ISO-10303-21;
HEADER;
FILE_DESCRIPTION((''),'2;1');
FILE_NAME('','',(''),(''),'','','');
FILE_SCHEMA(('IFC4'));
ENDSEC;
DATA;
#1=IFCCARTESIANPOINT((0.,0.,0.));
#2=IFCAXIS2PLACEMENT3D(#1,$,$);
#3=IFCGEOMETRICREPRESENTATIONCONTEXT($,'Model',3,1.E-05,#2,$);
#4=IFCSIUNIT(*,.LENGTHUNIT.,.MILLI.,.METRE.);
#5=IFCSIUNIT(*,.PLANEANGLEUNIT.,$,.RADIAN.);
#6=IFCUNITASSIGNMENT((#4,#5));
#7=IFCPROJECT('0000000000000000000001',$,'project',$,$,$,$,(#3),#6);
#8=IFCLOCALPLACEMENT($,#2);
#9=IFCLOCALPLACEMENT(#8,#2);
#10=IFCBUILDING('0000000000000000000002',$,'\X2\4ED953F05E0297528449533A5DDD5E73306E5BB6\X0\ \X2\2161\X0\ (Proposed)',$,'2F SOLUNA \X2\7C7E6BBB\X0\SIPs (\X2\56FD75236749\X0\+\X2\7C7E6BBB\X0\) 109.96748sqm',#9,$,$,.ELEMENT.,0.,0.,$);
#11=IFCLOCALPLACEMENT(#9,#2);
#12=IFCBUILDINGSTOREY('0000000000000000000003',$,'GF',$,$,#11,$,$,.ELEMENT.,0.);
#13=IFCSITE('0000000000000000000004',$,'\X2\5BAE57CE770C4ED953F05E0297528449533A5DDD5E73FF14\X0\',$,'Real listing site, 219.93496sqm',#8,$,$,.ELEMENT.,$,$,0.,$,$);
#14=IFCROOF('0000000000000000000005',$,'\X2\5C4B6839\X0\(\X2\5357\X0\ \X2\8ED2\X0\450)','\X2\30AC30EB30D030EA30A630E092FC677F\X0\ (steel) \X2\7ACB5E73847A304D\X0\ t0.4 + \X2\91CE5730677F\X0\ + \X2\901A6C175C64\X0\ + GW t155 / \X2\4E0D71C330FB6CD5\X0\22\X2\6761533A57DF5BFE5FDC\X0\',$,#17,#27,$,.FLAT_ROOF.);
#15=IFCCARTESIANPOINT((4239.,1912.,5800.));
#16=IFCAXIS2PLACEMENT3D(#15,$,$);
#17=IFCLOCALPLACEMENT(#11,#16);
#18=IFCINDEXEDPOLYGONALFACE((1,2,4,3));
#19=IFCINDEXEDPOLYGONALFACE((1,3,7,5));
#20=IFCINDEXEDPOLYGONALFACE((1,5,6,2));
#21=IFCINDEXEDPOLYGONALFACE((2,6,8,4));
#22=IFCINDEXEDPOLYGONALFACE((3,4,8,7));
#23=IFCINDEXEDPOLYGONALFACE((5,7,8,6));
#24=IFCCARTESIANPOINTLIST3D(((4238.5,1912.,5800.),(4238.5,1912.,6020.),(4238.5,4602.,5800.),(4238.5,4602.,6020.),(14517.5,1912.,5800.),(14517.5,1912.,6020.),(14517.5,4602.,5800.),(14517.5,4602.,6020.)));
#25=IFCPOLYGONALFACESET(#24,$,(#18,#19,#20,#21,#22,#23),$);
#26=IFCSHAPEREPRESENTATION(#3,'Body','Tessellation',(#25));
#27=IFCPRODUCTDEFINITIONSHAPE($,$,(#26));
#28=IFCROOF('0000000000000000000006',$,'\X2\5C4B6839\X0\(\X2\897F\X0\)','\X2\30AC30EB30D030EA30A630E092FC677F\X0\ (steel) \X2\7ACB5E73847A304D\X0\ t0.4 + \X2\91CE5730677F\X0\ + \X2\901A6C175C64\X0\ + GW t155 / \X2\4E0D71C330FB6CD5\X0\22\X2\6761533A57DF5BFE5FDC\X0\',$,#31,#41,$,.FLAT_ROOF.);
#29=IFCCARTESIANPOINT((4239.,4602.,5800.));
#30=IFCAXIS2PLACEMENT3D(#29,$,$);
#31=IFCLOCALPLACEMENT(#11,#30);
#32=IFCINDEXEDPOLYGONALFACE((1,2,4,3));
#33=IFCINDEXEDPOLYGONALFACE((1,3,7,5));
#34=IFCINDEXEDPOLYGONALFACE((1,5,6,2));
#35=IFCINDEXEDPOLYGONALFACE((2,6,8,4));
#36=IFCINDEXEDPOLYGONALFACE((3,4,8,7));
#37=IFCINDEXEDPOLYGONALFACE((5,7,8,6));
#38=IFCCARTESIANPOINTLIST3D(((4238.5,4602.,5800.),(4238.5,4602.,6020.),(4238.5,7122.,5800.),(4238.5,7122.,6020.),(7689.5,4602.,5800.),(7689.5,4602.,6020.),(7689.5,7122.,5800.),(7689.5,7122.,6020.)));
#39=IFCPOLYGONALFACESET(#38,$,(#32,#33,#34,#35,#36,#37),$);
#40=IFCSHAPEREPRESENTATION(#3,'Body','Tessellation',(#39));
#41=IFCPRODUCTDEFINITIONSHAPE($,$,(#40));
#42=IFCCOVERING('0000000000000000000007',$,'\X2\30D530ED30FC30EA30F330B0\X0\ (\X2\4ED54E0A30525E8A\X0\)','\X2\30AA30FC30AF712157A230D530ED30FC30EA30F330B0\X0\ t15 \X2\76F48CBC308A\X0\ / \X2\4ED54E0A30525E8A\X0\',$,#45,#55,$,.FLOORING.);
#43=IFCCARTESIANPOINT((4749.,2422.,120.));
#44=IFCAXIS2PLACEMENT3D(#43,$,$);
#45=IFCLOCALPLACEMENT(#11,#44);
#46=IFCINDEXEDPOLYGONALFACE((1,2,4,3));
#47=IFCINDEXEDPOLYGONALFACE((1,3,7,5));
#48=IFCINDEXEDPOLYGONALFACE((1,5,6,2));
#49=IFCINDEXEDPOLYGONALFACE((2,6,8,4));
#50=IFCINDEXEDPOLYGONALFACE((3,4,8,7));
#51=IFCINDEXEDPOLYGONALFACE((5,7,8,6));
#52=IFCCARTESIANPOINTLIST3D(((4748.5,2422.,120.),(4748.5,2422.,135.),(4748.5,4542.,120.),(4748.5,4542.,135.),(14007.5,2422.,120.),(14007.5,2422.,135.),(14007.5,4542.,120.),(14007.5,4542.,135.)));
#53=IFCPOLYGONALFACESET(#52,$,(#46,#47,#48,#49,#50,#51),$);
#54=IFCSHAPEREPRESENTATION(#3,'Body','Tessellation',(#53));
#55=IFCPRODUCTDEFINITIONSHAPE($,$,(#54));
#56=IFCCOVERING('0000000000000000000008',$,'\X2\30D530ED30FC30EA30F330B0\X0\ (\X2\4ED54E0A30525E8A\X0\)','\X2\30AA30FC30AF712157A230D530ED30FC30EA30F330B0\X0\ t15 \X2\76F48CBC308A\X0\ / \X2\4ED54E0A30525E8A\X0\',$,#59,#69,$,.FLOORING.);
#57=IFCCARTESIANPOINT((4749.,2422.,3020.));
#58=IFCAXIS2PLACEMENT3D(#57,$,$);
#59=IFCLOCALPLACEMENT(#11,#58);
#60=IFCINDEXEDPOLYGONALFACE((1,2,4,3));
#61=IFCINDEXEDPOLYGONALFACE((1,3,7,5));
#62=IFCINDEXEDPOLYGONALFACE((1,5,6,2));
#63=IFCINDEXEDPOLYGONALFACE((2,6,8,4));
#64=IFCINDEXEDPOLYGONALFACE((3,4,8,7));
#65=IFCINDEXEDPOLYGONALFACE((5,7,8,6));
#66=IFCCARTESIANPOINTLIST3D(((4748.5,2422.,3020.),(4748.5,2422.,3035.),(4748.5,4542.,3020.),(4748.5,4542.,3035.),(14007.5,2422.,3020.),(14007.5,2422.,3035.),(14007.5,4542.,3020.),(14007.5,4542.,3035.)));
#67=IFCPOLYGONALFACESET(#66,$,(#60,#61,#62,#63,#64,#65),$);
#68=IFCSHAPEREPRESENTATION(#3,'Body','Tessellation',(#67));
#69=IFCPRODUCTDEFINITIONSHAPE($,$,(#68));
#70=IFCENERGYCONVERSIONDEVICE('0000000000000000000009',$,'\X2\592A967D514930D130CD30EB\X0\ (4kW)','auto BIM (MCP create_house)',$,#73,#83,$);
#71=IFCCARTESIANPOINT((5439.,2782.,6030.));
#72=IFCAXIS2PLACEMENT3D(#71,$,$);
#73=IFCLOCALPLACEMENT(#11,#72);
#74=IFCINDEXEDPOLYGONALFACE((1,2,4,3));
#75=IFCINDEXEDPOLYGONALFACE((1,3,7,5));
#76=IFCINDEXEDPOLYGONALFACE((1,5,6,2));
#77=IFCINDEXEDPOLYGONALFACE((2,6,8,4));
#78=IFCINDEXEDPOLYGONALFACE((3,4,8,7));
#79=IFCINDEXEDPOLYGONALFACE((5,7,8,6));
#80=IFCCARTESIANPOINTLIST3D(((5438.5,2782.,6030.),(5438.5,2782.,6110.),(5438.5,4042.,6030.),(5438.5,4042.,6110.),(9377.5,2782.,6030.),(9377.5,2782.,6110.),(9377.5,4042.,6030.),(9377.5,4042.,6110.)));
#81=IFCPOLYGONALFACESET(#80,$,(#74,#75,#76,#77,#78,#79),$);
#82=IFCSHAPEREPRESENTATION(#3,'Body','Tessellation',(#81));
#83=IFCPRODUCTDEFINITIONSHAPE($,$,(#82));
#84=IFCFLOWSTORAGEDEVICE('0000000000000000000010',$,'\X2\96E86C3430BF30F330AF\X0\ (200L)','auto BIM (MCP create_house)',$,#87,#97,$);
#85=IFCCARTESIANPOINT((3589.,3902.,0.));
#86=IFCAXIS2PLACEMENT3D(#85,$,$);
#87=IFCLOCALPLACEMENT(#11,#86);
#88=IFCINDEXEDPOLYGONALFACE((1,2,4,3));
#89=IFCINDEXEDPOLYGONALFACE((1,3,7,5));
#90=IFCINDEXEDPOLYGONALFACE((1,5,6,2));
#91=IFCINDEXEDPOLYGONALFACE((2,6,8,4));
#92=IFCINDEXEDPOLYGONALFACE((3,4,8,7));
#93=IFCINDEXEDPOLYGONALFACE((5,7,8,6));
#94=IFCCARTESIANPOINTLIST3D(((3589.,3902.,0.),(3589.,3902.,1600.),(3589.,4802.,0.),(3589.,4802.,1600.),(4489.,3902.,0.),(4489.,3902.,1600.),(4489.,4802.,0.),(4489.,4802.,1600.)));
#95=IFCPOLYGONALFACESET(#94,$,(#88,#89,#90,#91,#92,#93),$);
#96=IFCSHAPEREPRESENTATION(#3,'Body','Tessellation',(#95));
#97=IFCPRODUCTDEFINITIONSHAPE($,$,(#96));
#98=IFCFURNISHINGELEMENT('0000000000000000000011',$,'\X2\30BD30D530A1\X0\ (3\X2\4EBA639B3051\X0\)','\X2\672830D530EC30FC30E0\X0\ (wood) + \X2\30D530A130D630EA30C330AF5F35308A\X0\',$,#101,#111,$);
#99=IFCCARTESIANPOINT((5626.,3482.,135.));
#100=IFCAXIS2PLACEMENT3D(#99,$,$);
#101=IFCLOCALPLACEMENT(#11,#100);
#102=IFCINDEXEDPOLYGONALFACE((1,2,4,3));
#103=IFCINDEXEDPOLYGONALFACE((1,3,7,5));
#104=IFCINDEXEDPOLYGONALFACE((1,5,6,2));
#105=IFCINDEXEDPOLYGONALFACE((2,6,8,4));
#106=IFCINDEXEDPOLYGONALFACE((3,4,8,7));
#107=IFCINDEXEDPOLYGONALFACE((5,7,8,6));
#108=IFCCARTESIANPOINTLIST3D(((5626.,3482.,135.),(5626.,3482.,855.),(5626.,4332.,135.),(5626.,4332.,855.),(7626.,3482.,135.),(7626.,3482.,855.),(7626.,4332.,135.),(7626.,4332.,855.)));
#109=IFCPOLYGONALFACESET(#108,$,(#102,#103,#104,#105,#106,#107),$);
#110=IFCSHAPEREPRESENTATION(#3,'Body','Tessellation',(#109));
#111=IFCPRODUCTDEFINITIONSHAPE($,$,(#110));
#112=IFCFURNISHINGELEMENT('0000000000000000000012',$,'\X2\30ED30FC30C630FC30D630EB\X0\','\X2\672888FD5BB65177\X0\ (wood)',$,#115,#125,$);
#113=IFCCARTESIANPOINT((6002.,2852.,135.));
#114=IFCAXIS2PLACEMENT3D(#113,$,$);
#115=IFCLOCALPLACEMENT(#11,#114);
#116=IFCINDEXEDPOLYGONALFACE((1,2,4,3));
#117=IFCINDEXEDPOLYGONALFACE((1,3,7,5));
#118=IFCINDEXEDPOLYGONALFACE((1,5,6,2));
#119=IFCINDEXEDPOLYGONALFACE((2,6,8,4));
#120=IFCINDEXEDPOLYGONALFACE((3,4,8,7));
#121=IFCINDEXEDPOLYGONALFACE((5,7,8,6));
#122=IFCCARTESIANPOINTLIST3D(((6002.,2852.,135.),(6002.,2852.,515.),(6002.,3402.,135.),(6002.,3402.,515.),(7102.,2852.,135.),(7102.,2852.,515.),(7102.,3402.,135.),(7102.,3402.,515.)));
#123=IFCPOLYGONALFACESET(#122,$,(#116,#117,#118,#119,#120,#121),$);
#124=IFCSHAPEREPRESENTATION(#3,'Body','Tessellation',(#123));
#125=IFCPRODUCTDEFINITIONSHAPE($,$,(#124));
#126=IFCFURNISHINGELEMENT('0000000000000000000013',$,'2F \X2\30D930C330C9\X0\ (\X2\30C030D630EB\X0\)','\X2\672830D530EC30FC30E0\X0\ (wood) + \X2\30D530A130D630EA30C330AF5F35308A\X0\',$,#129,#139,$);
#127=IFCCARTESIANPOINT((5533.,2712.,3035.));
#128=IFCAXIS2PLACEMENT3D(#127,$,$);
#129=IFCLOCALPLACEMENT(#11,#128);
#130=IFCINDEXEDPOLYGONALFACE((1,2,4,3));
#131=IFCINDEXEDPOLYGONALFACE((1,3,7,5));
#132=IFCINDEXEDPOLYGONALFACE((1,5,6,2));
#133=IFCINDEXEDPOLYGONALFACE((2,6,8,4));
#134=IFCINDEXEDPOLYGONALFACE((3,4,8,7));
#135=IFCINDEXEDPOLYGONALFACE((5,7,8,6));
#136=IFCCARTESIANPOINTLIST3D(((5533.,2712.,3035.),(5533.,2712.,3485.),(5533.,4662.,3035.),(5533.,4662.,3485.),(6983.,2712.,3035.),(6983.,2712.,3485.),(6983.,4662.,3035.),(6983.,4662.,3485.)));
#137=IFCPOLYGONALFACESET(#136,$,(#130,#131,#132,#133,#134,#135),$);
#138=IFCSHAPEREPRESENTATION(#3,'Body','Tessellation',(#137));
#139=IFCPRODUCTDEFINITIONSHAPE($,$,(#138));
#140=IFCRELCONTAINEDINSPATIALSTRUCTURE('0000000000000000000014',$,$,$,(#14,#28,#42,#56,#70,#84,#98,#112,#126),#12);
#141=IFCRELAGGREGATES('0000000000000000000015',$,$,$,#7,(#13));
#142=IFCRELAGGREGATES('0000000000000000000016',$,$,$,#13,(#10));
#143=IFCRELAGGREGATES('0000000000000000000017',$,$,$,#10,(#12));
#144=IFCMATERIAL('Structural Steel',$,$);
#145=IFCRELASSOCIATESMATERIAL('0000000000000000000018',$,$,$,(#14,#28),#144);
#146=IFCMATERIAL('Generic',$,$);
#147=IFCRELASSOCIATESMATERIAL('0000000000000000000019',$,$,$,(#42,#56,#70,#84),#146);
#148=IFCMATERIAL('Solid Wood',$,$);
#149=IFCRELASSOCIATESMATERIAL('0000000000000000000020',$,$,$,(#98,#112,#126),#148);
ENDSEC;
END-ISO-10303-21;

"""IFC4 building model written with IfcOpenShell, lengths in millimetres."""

from ifc_helpers import new_model, si_unit, frame, frame_2d, origin, place, context, project, spatial, rectangle, extrude, material, element, save


model = new_model("IFC4")

# Units and contexts
model_context = context("Model", 3, precision=1e-05, world=origin())
ifc_project = project(units=[si_unit("LENGTHUNIT", "METRE", prefix="MILLI"), si_unit("PLANEANGLEUNIT", "RADIAN")], contexts=[model_context])

# Site, building, storey
site_placement = place(None, origin())
site = spatial("IfcSite", under=ifc_project, at=site_placement, Name="宮城県仙台市青葉区川平４", ObjectType="Real listing site, 219.93496sqm", CompositionType="ELEMENT", RefElevation=0.0)
building_placement = place(site_placement, origin())
building = spatial("IfcBuilding", under=site, at=building_placement, Name="仙台市青葉区川平の家 Ⅱ (Proposed)", ObjectType="2F SOLUNA 籾殻SIPs (国産杉+籾殻) 109.96748sqm", CompositionType="ELEMENT", ElevationOfRefHeight=0.0, ElevationOfTerrain=0.0)
storey_placement = place(building_placement, origin())
storey = spatial("IfcBuildingStorey", under=building, at=storey_placement, Name="GF", CompositionType="ELEMENT", Elevation=0.0)

# Shared definitions
ifc_material_1 = material(Name="Solid Wood")

# Roofs
ifc_material_2 = material(Name="Structural Steel")
roof_1_placement = place(storey_placement, frame((4239.0, 1912.0, 5800.0)))
element("IfcRoof", 1, at=roof_1_placement, inside=storey, material=ifc_material_2, Name="屋根(南 軒450)", Description="ガルバリウム鋼板 (steel) 立平葺き t0.4 + 野地板 + 通気層 + GW t155 / 不燃・法22条区域対応", PredefinedType="FLAT_ROOF", context=model_context, shape_type="SweptSolid", body=[
    extrude(rectangle(XDim=10279.0, YDim=2690.0, at=frame_2d((5139.0, 1345.0))), frame((4239.0, 1912.0, 5800.0)), (0.0, 0.0, 1.0), 220.0),
])
roof_2_placement = place(storey_placement, frame((4239.0, 4602.0, 5800.0)))
element("IfcRoof", 2, at=roof_2_placement, inside=storey, material=ifc_material_2, Name="屋根(西)", Description="ガルバリウム鋼板 (steel) 立平葺き t0.4 + 野地板 + 通気層 + GW t155 / 不燃・法22条区域対応", PredefinedType="FLAT_ROOF", context=model_context, shape_type="SweptSolid", body=[
    extrude(rectangle(XDim=3451.0, YDim=2520.0, at=frame_2d((1725.0, 1260.0))), frame((4239.0, 4602.0, 5800.0)), (0.0, 0.0, 1.0), 220.0),
])

# Coverings
ifc_material_3 = material(Name="Generic")
covering_1_placement = place(storey_placement, frame((4749.0, 2422.0, 120.0)))
element("IfcCovering", 3, at=covering_1_placement, inside=storey, material=ifc_material_3, Name="フローリング (仕上げ床)", Description="オーク無垢フローリング t15 直貼り / 仕上げ床", PredefinedType="FLOORING", context=model_context, shape_type="SweptSolid", body=[
    extrude(rectangle(XDim=9259.0, YDim=2120.0, at=frame_2d((4629.0, 1060.0))), frame((4749.0, 2422.0, 120.0)), (0.0, 0.0, 1.0), 15.0),
])
covering_2_placement = place(storey_placement, frame((4749.0, 2422.0, 3020.0)))
element("IfcCovering", 4, at=covering_2_placement, inside=storey, material=ifc_material_3, Name="フローリング (仕上げ床)", Description="オーク無垢フローリング t15 直貼り / 仕上げ床", PredefinedType="FLOORING", context=model_context, shape_type="SweptSolid", body=[
    extrude(rectangle(XDim=9259.0, YDim=2120.0, at=frame_2d((4629.0, 1060.0))), frame((4749.0, 2422.0, 3020.0)), (0.0, 0.0, 1.0), 15.0),
])

# Energy conversion device
energy_conversion_device_placement = place(storey_placement, frame((5439.0, 2782.0, 6030.0)))
element("IfcEnergyConversionDevice", 5, at=energy_conversion_device_placement, inside=storey, material=ifc_material_3, Name="太陽光パネル (4kW)", Description="auto BIM (MCP create_house)", context=model_context, shape_type="SweptSolid", body=[
    extrude(rectangle(XDim=3939.0, YDim=1260.0, at=frame_2d((1969.0, 630.0))), frame((5439.0, 2782.0, 6030.0)), (0.0, 0.0, 1.0), 80.0),
])

# Flow storage device
flow_storage_device_placement = place(storey_placement, frame((3589.0, 3902.0, 0.0)))
element("IfcFlowStorageDevice", 6, at=flow_storage_device_placement, inside=storey, material=ifc_material_3, Name="雨水タンク (200L)", Description="auto BIM (MCP create_house)", context=model_context, shape_type="SweptSolid", body=[
    extrude(rectangle(XDim=900.0, YDim=900.0, at=frame_2d((450.0, 450.0))), frame((3589.0, 3902.0, 0.0)), (0.0, 0.0, 1.0), 1600.0),
])

# Furnishing elements
furnishing_1_placement = place(storey_placement, frame((5626.0, 3482.0, 135.0)))
element("IfcFurnishingElement", 7, at=furnishing_1_placement, inside=storey, material=ifc_material_1, Name="ソファ (3人掛け)", Description="木フレーム (wood) + ファブリック張り", context=model_context, shape_type="SweptSolid", body=[
    extrude(rectangle(XDim=2000.0, YDim=850.0, at=frame_2d((1000.0, 425.0))), frame((5626.0, 3482.0, 135.0)), (0.0, 0.0, 1.0), 720.0),
])
furnishing_2_placement = place(storey_placement, frame((6002.0, 2852.0, 135.0)))
element("IfcFurnishingElement", 8, at=furnishing_2_placement, inside=storey, material=ifc_material_1, Name="ローテーブル", Description="木製家具 (wood)", context=model_context, shape_type="SweptSolid", body=[
    extrude(rectangle(XDim=1100.0, YDim=550.0, at=frame_2d((550.0, 275.0))), frame((6002.0, 2852.0, 135.0)), (0.0, 0.0, 1.0), 380.0),
])
furnishing_3_placement = place(storey_placement, frame((5533.0, 2712.0, 3035.0)))
element("IfcFurnishingElement", 9, at=furnishing_3_placement, inside=storey, material=ifc_material_1, Name="2F ベッド (ダブル)", Description="木フレーム (wood) + ファブリック張り", context=model_context, shape_type="SweptSolid", body=[
    extrude(rectangle(XDim=1450.0, YDim=1950.0, at=frame_2d((725.0, 975.0))), frame((5533.0, 2712.0, 3035.0)), (0.0, 0.0, 1.0), 450.0),
])

save(model, "model.ifc")
